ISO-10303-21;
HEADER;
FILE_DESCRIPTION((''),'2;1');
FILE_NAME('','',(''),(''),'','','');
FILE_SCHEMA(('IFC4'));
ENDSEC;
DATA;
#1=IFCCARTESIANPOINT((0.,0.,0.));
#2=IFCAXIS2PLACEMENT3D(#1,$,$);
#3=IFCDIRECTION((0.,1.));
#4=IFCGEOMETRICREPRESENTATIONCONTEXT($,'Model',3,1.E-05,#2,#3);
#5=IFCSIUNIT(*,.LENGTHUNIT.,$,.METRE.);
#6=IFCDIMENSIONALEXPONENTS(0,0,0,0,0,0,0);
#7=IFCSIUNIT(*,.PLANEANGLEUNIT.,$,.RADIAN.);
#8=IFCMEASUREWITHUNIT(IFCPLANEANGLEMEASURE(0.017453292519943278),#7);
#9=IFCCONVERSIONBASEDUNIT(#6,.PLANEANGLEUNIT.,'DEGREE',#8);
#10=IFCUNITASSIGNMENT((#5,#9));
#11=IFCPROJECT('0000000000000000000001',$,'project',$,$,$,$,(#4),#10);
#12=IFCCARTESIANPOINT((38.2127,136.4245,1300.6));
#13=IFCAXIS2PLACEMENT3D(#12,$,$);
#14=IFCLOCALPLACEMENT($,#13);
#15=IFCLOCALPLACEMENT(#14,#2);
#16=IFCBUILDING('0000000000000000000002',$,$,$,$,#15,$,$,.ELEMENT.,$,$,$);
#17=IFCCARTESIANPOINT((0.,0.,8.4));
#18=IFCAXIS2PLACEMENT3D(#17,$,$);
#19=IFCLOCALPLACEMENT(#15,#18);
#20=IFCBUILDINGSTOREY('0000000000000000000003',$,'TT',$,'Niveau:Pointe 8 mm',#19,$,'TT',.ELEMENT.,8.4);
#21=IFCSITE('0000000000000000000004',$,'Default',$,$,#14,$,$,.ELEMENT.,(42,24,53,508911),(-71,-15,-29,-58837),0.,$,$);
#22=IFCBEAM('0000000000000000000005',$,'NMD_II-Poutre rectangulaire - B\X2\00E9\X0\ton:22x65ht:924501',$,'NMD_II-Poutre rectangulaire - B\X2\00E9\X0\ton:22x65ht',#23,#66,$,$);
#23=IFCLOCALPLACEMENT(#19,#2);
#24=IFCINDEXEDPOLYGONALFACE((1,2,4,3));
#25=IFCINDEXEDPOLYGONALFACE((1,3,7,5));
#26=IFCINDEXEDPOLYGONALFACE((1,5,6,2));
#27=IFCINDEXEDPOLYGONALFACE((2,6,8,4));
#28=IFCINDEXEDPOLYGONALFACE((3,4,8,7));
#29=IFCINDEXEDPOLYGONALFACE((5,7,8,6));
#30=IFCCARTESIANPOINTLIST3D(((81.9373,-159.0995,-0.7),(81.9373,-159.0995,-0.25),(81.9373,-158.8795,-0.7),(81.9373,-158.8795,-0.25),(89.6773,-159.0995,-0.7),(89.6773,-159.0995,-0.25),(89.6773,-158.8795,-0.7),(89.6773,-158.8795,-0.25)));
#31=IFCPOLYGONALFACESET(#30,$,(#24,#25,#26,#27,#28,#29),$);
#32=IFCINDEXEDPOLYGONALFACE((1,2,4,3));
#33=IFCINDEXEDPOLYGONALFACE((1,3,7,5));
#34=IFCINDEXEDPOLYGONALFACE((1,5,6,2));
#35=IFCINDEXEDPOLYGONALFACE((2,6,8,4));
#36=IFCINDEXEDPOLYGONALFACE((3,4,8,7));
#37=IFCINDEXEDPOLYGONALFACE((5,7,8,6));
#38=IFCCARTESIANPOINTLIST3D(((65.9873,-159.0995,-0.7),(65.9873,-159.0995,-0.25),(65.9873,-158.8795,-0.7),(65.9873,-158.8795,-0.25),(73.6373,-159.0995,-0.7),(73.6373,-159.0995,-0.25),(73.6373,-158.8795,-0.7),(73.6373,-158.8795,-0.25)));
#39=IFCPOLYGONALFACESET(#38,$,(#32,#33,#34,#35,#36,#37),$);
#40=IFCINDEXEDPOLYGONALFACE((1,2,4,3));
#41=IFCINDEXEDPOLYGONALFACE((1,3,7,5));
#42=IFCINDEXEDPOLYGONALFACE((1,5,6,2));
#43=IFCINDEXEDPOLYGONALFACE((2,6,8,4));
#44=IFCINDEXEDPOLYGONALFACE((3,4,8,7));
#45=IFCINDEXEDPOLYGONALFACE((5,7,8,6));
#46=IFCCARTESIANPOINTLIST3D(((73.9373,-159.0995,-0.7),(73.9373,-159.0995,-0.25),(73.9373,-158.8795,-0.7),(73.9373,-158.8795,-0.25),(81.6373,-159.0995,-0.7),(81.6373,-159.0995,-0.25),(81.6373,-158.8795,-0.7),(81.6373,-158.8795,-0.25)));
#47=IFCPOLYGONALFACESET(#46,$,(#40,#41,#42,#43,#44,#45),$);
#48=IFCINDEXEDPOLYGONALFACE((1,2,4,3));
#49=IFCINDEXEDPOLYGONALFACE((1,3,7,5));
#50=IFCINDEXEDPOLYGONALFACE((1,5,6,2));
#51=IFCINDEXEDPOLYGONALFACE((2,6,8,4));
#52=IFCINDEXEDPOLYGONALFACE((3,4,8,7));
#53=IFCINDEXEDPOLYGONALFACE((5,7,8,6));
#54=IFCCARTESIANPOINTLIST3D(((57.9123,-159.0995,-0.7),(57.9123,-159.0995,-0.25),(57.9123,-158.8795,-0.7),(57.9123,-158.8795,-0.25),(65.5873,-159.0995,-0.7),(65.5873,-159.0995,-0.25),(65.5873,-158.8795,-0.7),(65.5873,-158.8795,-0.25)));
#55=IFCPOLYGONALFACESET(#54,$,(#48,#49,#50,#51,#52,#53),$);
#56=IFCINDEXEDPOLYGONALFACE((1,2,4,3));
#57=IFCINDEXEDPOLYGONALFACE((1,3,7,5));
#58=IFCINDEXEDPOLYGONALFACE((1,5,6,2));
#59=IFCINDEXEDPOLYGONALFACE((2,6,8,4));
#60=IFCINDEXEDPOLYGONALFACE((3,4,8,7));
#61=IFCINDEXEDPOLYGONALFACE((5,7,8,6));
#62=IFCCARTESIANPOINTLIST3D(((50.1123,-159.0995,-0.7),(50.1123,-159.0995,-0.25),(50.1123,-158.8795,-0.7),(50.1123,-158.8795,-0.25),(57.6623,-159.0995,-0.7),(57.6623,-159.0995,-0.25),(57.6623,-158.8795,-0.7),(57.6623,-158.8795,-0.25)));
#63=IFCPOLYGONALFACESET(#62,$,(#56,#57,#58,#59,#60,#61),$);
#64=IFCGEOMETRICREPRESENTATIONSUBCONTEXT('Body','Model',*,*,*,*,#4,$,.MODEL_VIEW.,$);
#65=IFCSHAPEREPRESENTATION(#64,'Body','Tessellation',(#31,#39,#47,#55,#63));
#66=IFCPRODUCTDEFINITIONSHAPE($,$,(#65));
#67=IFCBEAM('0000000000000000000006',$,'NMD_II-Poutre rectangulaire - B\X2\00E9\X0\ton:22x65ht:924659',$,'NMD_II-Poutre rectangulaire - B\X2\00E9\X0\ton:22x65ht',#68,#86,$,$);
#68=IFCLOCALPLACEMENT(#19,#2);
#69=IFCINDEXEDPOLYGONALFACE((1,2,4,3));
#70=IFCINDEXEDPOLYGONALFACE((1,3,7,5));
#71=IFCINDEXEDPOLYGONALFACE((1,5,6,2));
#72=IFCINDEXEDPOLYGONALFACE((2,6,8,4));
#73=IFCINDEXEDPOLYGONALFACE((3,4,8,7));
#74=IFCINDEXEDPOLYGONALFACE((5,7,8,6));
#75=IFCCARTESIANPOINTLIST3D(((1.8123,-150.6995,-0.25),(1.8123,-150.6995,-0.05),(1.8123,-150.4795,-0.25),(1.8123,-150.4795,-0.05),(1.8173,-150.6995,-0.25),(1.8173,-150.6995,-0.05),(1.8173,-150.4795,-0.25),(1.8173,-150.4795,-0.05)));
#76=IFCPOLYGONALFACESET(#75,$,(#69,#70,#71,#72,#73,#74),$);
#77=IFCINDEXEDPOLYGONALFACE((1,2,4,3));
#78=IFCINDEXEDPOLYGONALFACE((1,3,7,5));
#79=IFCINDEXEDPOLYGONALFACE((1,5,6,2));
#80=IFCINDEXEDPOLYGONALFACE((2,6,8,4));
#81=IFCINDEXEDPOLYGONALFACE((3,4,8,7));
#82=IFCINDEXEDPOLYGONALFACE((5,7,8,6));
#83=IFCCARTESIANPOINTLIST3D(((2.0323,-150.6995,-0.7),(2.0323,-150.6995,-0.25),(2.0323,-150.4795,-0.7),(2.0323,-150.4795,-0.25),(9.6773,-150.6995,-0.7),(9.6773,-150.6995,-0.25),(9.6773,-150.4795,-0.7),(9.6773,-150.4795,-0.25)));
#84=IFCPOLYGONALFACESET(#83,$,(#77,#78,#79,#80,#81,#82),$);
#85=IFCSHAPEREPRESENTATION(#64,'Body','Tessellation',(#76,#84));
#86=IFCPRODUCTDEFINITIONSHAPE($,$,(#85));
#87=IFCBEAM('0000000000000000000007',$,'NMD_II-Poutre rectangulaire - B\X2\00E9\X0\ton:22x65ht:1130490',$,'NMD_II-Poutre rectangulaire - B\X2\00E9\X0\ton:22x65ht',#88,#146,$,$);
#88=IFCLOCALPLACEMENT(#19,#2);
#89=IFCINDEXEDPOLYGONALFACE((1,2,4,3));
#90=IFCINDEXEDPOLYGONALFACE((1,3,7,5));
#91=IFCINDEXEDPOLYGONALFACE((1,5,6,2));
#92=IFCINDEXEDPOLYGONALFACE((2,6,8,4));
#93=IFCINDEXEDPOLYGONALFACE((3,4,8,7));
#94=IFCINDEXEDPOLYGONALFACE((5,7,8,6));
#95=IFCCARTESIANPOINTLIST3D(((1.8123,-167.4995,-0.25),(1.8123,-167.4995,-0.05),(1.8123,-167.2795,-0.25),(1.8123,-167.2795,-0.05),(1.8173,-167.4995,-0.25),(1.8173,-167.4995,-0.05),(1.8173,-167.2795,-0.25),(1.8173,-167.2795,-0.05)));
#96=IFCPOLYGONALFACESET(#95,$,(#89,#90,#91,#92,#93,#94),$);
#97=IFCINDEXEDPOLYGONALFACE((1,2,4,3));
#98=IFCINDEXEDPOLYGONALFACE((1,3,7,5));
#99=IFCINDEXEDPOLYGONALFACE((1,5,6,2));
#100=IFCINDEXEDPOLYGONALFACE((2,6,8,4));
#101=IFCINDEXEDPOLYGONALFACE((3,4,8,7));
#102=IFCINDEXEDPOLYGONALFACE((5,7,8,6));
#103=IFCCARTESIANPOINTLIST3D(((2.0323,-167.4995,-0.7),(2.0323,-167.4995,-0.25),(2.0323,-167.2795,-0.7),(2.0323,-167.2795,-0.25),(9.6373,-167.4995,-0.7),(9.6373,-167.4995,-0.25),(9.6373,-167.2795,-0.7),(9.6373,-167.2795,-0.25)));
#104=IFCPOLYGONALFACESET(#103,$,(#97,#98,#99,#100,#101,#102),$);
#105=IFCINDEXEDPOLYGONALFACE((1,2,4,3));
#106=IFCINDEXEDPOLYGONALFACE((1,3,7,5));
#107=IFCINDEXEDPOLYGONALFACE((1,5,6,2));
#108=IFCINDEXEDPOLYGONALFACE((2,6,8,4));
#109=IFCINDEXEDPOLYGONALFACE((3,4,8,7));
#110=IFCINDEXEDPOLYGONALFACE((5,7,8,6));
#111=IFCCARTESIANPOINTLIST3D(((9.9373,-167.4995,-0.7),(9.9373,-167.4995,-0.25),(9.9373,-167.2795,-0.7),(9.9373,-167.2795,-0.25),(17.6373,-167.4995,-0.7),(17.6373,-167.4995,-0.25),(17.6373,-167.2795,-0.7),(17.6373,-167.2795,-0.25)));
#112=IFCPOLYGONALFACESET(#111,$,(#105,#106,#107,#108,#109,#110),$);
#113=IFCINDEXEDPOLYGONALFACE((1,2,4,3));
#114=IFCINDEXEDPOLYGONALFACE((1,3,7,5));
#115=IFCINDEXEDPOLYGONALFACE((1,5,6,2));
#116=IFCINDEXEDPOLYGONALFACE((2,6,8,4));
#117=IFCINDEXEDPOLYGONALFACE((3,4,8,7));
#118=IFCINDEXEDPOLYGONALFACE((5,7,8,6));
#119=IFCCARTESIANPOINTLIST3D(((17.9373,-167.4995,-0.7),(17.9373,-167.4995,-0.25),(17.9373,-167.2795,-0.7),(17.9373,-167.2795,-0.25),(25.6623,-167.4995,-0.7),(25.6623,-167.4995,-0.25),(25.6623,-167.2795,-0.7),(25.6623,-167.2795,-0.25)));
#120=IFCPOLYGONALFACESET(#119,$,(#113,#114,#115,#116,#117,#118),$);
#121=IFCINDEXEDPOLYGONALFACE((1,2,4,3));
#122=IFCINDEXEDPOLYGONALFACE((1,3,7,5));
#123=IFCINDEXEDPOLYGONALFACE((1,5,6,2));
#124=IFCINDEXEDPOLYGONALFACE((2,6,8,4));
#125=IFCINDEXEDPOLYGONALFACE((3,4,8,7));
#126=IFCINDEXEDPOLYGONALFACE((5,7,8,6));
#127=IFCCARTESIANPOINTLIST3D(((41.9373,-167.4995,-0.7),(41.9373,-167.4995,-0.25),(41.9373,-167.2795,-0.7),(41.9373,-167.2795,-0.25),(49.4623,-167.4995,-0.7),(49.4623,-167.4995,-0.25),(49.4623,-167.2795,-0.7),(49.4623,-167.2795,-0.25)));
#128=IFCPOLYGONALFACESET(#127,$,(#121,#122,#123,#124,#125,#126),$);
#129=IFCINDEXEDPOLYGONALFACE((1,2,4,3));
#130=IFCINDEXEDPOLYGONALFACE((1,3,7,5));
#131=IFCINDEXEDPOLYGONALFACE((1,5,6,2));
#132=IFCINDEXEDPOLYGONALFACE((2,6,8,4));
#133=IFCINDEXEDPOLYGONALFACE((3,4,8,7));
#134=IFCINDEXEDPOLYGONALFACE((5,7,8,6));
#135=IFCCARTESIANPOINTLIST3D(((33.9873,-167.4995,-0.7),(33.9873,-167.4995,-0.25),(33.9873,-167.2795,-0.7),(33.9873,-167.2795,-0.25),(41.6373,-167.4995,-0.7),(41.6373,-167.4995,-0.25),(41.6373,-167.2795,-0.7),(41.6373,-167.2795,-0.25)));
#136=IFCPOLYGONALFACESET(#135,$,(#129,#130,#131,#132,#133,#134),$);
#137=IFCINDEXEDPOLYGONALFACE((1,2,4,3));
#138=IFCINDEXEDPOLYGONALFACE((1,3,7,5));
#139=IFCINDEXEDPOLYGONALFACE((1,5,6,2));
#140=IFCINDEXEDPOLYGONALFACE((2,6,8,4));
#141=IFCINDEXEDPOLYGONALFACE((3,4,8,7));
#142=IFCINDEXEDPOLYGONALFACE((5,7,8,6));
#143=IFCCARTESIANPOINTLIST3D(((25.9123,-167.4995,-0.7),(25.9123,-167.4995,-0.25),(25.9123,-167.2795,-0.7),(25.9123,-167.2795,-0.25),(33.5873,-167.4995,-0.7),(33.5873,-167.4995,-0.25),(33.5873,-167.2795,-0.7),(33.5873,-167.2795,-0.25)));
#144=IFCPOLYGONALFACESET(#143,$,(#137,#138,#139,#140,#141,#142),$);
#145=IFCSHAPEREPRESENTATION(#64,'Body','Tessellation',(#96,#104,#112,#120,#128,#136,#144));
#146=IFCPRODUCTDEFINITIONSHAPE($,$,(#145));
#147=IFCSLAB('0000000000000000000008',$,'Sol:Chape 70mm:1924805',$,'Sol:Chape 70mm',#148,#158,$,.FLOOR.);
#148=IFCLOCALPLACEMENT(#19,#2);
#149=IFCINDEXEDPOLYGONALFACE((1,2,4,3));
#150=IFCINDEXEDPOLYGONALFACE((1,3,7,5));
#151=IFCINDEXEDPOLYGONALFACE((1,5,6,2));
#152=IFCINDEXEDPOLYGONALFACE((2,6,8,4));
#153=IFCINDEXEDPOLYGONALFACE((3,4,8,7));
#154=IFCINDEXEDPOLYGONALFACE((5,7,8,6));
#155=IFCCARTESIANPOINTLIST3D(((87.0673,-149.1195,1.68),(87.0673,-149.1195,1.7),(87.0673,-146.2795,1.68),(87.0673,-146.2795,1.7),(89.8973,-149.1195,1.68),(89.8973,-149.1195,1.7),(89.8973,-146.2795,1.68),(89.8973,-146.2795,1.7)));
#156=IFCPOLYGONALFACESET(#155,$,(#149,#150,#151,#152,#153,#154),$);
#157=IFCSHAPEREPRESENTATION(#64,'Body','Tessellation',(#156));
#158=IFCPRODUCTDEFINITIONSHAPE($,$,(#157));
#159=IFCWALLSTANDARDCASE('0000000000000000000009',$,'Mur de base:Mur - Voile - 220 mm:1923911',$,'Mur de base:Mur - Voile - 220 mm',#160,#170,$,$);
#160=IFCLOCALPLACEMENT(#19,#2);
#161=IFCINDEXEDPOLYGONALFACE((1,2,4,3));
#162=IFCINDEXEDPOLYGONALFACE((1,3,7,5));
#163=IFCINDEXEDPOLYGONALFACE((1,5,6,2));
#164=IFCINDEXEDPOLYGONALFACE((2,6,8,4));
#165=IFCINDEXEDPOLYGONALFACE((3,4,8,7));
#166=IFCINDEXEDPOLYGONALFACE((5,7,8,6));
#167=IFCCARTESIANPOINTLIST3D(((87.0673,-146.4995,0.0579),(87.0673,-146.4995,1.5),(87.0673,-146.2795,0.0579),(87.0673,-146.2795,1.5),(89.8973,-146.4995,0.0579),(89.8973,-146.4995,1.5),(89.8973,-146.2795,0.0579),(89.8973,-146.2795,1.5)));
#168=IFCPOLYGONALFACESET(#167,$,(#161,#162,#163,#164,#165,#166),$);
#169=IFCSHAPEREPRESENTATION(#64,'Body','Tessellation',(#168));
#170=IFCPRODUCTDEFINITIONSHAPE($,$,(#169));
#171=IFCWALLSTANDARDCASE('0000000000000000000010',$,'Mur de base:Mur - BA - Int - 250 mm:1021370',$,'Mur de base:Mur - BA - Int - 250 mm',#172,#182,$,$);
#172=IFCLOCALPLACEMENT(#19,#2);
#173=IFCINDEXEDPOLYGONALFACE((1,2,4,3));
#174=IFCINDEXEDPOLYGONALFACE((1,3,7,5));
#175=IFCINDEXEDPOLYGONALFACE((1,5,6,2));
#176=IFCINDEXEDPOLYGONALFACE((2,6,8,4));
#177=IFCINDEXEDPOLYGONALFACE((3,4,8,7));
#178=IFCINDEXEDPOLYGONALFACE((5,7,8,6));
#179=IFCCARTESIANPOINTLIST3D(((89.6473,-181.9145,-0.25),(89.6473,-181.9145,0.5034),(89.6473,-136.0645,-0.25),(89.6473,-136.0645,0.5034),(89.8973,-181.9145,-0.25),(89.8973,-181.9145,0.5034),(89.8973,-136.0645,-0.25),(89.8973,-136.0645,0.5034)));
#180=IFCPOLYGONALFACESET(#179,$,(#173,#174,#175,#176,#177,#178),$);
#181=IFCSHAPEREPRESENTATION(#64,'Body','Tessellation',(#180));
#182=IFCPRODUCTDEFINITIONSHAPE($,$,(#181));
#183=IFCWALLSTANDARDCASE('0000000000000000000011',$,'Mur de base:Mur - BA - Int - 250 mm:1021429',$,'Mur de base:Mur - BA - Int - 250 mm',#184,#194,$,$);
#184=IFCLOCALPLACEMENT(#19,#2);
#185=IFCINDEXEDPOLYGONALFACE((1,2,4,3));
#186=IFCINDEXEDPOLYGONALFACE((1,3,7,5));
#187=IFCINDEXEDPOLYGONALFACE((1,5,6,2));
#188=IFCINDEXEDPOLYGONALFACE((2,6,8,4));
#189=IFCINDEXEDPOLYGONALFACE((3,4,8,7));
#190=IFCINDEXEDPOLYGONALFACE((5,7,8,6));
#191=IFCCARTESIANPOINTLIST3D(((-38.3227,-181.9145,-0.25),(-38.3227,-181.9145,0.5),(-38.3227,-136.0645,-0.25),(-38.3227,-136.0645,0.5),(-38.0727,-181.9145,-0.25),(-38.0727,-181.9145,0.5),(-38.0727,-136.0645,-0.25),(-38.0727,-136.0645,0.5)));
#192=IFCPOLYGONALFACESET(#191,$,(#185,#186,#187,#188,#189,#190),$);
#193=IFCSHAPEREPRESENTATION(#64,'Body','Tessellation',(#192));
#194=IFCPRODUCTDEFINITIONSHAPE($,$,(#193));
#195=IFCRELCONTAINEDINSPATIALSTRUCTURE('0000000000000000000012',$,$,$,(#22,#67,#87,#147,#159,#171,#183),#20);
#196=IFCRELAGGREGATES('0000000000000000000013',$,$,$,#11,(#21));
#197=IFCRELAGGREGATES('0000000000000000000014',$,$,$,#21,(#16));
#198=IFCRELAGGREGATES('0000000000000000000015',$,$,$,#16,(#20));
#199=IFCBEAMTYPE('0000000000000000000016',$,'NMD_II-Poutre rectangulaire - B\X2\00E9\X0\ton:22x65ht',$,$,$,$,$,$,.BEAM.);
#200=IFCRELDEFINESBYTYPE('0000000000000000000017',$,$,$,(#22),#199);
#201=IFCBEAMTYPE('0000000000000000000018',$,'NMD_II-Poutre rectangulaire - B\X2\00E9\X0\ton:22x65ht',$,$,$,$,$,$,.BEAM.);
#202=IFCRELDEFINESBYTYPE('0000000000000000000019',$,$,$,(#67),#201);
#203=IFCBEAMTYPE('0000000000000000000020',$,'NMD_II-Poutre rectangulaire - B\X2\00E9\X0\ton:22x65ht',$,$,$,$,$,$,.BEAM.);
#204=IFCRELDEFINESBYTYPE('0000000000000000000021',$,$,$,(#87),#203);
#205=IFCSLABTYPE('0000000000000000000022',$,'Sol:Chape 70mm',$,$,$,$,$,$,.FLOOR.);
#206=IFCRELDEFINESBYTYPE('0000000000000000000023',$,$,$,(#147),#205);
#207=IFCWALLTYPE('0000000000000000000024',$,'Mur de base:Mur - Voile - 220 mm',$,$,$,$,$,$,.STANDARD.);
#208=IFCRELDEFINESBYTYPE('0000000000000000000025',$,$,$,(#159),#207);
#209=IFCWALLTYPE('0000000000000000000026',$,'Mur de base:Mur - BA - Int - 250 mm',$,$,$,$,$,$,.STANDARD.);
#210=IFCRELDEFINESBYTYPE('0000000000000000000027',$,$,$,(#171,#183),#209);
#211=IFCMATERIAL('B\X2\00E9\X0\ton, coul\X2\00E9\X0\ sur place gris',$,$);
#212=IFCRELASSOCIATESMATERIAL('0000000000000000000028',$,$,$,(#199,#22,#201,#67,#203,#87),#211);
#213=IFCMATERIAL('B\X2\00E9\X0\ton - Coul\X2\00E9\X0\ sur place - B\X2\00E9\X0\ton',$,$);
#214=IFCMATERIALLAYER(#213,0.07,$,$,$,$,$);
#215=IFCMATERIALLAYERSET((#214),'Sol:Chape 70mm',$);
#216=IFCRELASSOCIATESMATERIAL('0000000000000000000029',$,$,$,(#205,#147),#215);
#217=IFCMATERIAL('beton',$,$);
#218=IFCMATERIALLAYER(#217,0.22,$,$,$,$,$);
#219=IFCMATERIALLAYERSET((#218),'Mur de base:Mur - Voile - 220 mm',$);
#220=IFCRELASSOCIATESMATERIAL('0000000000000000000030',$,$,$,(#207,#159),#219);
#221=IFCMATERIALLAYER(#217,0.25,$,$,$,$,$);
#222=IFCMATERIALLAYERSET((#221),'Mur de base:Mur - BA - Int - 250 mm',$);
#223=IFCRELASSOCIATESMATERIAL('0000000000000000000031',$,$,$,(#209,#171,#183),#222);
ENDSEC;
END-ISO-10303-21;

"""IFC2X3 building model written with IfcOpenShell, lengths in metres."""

from ifc_helpers import new_model, entity, si_unit, converted_unit, direction, frame, frame_2d, origin, place, context, subcontext, project, spatial, rectangle, extrude, source, transform, mapped, material, layer, layer_set, layer_usage, type_object, type_shapes, element, save


model = new_model("IFC2X3")

# Units and contexts
model_context = context("Model", 3, precision=1e-05, world=origin(), true_north=direction((0.0, 1.0)))
body_context = subcontext(model_context, "Body", "Model", "MODEL_VIEW")
ifc_project = project(units=[si_unit("LENGTHUNIT", "METRE"), converted_unit("PLANEANGLEUNIT", "DEGREE", entity("IfcPlaneAngleMeasure", 0.017453292519943278), si_unit("PLANEANGLEUNIT", "RADIAN"), dimensions=[0, 0, 0, 0, 0, 0, 0])], contexts=[model_context])

# Site, building, storey
site_placement = place(None, frame((38.2127, 136.4245, 1300.6)))
site = spatial("IfcSite", under=ifc_project, at=site_placement, Name="Default", CompositionType="ELEMENT", RefLatitude=(42, 24, 53, 508911), RefLongitude=(-71, -15, -29, -58837), RefElevation=0.0)
building_placement = place(site_placement, origin())
building = spatial("IfcBuilding", under=site, at=building_placement, CompositionType="ELEMENT")
storey_placement = place(building_placement, frame((0.0, 0.0, 8.4)))
storey = spatial("IfcBuildingStorey", under=building, at=storey_placement, Name="TT", ObjectType="Niveau:Pointe 8 mm", LongName="TT", CompositionType="ELEMENT", Elevation=8.4)

# Beams
ifc_material_1 = material(Name="Béton, coulé sur place gris")
beam_type_1 = type_object("IfcBeamType", Name="NMD_II-Poutre rectangulaire - Béton:22x65ht", PredefinedType="BEAM", material=ifc_material_1)
shared_shape_1 = source(origin(), body_context, "Body", "SweptSolid", [
    extrude(rectangle(XDim=0.45, YDim=0.22, at=frame_2d((0.0, 0.0), x_axis=(1.0, 0.0))), frame((81.9373, -158.9895, 7.925), z_axis=(1.0, 0.0, 0.0), x_axis=(0.0, 0.0, -1.0)), (0.0, 0.0, 1.0), 7.74),
    extrude(rectangle(XDim=0.45, YDim=0.22, at=frame_2d((0.0, 0.0), x_axis=(1.0, 0.0))), frame((65.9873, -158.9895, 7.925), z_axis=(1.0, 0.0, 0.0), x_axis=(0.0, 0.0, -1.0)), (0.0, 0.0, 1.0), 7.65),
    extrude(rectangle(XDim=0.45, YDim=0.22, at=frame_2d((0.0, 0.0), x_axis=(1.0, 0.0))), frame((73.9373, -158.9895, 7.925), z_axis=(1.0, 0.0, 0.0), x_axis=(0.0, 0.0, -1.0)), (0.0, 0.0, 1.0), 7.7),
    extrude(rectangle(XDim=0.45, YDim=0.22, at=frame_2d((0.0, 0.0), x_axis=(1.0, 0.0))), frame((57.9123, -158.9895, 7.925), z_axis=(1.0, 0.0, 0.0), x_axis=(0.0, 0.0, -1.0)), (0.0, 0.0, 1.0), 7.675),
    extrude(rectangle(XDim=0.45, YDim=0.22, at=frame_2d((0.0, 0.0), x_axis=(1.0, 0.0))), frame((50.1123, -158.9895, 7.925), z_axis=(1.0, 0.0, 0.0), x_axis=(0.0, 0.0, -1.0)), (0.0, 0.0, 1.0), 7.55),
])
type_shapes(beam_type_1, [shared_shape_1])
beam_1_placement = place(storey_placement, frame((0.0, 0.0, -8.4)))
element("IfcBeam", 1, at=beam_1_placement, inside=storey, type_object=beam_type_1, material=ifc_material_1, Name="NMD_II-Poutre rectangulaire - Béton:22x65ht:924501", ObjectType="NMD_II-Poutre rectangulaire - Béton:22x65ht", context=body_context, shape_type="MappedRepresentation", body=[
    mapped(shared_shape_1, transform((0.0, 0.0, 0.0), scale=1.0)),
])
beam_type_2 = type_object("IfcBeamType", Name="NMD_II-Poutre rectangulaire - Béton:22x65ht", PredefinedType="BEAM", material=ifc_material_1)
shared_shape_2 = source(origin(), body_context, "Body", "SweptSolid", [
    extrude(rectangle(XDim=0.2, YDim=0.22, at=frame_2d((0.0, 0.0), x_axis=(1.0, 0.0))), frame((1.8123, -150.5895, 8.25), z_axis=(1.0, 0.0, 0.0), x_axis=(0.0, 0.0, -1.0)), (0.0, 0.0, 1.0), 0.005),
    extrude(rectangle(XDim=0.45, YDim=0.22, at=frame_2d((0.0, 0.0), x_axis=(1.0, 0.0))), frame((2.0323, -150.5895, 7.925), z_axis=(1.0, 0.0, 0.0), x_axis=(0.0, 0.0, -1.0)), (0.0, 0.0, 1.0), 7.645),
])
type_shapes(beam_type_2, [shared_shape_2])
beam_2_placement = place(storey_placement, frame((0.0, 0.0, -8.4)))
element("IfcBeam", 2, at=beam_2_placement, inside=storey, type_object=beam_type_2, material=ifc_material_1, Name="NMD_II-Poutre rectangulaire - Béton:22x65ht:924659", ObjectType="NMD_II-Poutre rectangulaire - Béton:22x65ht", context=body_context, shape_type="MappedRepresentation", body=[
    mapped(shared_shape_2, transform((0.0, 0.0, 0.0), scale=1.0)),
])
beam_type_3 = type_object("IfcBeamType", Name="NMD_II-Poutre rectangulaire - Béton:22x65ht", PredefinedType="BEAM", material=ifc_material_1)
shared_shape_3 = source(origin(), body_context, "Body", "SweptSolid", [
    extrude(rectangle(XDim=0.2, YDim=0.22, at=frame_2d((0.0, 0.0), x_axis=(1.0, 0.0))), frame((1.8123, -167.3895, 8.25), z_axis=(1.0, 0.0, 0.0), x_axis=(0.0, 0.0, -1.0)), (0.0, 0.0, 1.0), 0.005),
    extrude(rectangle(XDim=0.45, YDim=0.22, at=frame_2d((0.0, 0.0), x_axis=(1.0, 0.0))), frame((2.0323, -167.3895, 7.925), z_axis=(1.0, 0.0, 0.0), x_axis=(0.0, 0.0, -1.0)), (0.0, 0.0, 1.0), 7.605),
    extrude(rectangle(XDim=0.45, YDim=0.22, at=frame_2d((0.0, 0.0), x_axis=(1.0, 0.0))), frame((9.9373, -167.3895, 7.925), z_axis=(1.0, 0.0, 0.0), x_axis=(0.0, 0.0, -1.0)), (0.0, 0.0, 1.0), 7.7),
    extrude(rectangle(XDim=0.45, YDim=0.22, at=frame_2d((0.0, 0.0), x_axis=(1.0, 0.0))), frame((17.9373, -167.3895, 7.925), z_axis=(1.0, 0.0, 0.0), x_axis=(0.0, 0.0, -1.0)), (0.0, 0.0, 1.0), 7.725),
    extrude(rectangle(XDim=0.45, YDim=0.22, at=frame_2d((0.0, 0.0), x_axis=(1.0, 0.0))), frame((41.9373, -167.3895, 7.925), z_axis=(1.0, 0.0, 0.0), x_axis=(0.0, 0.0, -1.0)), (0.0, 0.0, 1.0), 7.525),
    extrude(rectangle(XDim=0.45, YDim=0.22, at=frame_2d((0.0, 0.0), x_axis=(1.0, 0.0))), frame((33.9873, -167.3895, 7.925), z_axis=(1.0, 0.0, 0.0), x_axis=(0.0, 0.0, -1.0)), (0.0, 0.0, 1.0), 7.65),
    extrude(rectangle(XDim=0.45, YDim=0.22, at=frame_2d((0.0, 0.0), x_axis=(1.0, 0.0))), frame((25.9123, -167.3895, 7.925), z_axis=(1.0, 0.0, 0.0), x_axis=(0.0, 0.0, -1.0)), (0.0, 0.0, 1.0), 7.675),
])
type_shapes(beam_type_3, [shared_shape_3])
beam_3_placement = place(storey_placement, frame((0.0, 0.0, -8.4)))
element("IfcBeam", 3, at=beam_3_placement, inside=storey, type_object=beam_type_3, material=ifc_material_1, Name="NMD_II-Poutre rectangulaire - Béton:22x65ht:1130490", ObjectType="NMD_II-Poutre rectangulaire - Béton:22x65ht", context=body_context, shape_type="MappedRepresentation", body=[
    mapped(shared_shape_3, transform((0.0, 0.0, 0.0), scale=1.0)),
])

# Slab
ifc_material_2 = material(Name="Béton - Coulé sur place - Béton")
ifc_layer_1 = layer(ifc_material_2, 0.07)
ifc_layer_set_1 = layer_set([ifc_layer_1], Name="Sol:Chape 70mm")
ifc_layer_usage_1 = layer_usage(ifc_layer_set_1, "AXIS3", "POSITIVE", 0.0)
slab_type = type_object("IfcSlabType", Name="Sol:Chape 70mm", PredefinedType="FLOOR", material=ifc_layer_set_1)
slab_placement = place(storey_placement, origin())
element("IfcSlab", 4, at=slab_placement, inside=storey, type_object=slab_type, material=ifc_layer_usage_1, Name="Sol:Chape 70mm:1924805", ObjectType="Sol:Chape 70mm", PredefinedType="FLOOR", context=body_context, shape_type="SweptSolid", body=[
    extrude(rectangle(XDim=2.84, YDim=2.83, at=frame_2d((0.0, 0.0), x_axis=(1.0, 0.0))), frame((88.4823, -147.6995, 1.7), z_axis=(0.0, 0.0, -1.0), x_axis=(0.0, 1.0, 0.0)), (0.0, 0.0, 1.0), 0.02),
])

# Walls
ifc_material_3 = material(Name="beton")
ifc_layer_2 = layer(ifc_material_3, 0.22)
ifc_layer_set_2 = layer_set([ifc_layer_2], Name="Mur de base:Mur - Voile - 220 mm")
ifc_layer_usage_2 = layer_usage(ifc_layer_set_2, "AXIS2", "NEGATIVE", 0.11)
wall_type_1 = type_object("IfcWallType", Name="Mur de base:Mur - Voile - 220 mm", PredefinedType="STANDARD", material=ifc_layer_set_2)
wall_1_placement = place(storey_placement, frame((87.0673, -146.3895, 0.0579)))
element("IfcWallStandardCase", 5, at=wall_1_placement, inside=storey, type_object=wall_type_1, material=ifc_layer_usage_2, Name="Mur de base:Mur - Voile - 220 mm:1923911", ObjectType="Mur de base:Mur - Voile - 220 mm", context=body_context, shape_type="SweptSolid", body=[
    extrude(rectangle(XDim=2.83, YDim=0.22, at=frame_2d((1.415, 0.0), x_axis=(-1.0, 0.0))), origin(), (0.0, 0.0, 1.0), 1.4421),
])
ifc_layer_3 = layer(ifc_material_3, 0.25)
ifc_layer_set_3 = layer_set([ifc_layer_3], Name="Mur de base:Mur - BA - Int - 250 mm")
ifc_layer_usage_3 = layer_usage(ifc_layer_set_3, "AXIS2", "NEGATIVE", 0.125)
wall_type_2 = type_object("IfcWallType", Name="Mur de base:Mur - BA - Int - 250 mm", PredefinedType="STANDARD", material=ifc_layer_set_3)
wall_2_placement = place(storey_placement, frame((89.7723, -136.0645, -0.25), z_axis=(0.0, 0.0, 1.0), x_axis=(0.0, -1.0, 0.0)))
element("IfcWallStandardCase", 6, at=wall_2_placement, inside=storey, type_object=wall_type_2, material=ifc_layer_usage_3, Name="Mur de base:Mur - BA - Int - 250 mm:1021370", ObjectType="Mur de base:Mur - BA - Int - 250 mm", context=body_context, shape_type="SweptSolid", body=[
    extrude(rectangle(XDim=45.85, YDim=0.25, at=frame_2d((22.925, 0.0), x_axis=(-1.0, 0.0))), origin(), (0.0, 0.0, 1.0), 0.7534),
])
ifc_layer_usage_4 = layer_usage(ifc_layer_set_3, "AXIS2", "NEGATIVE", 0.125)
wall_3_placement = place(storey_placement, frame((-38.1977, -136.0645, -0.25), z_axis=(0.0, 0.0, 1.0), x_axis=(0.0, -1.0, 0.0)))
element("IfcWallStandardCase", 7, at=wall_3_placement, inside=storey, type_object=wall_type_2, material=ifc_layer_usage_4, Name="Mur de base:Mur - BA - Int - 250 mm:1021429", ObjectType="Mur de base:Mur - BA - Int - 250 mm", context=body_context, shape_type="SweptSolid", body=[
    extrude(rectangle(XDim=45.85, YDim=0.25, at=frame_2d((22.925, 0.0), x_axis=(-1.0, 0.0))), origin(), (0.0, 0.0, 1.0), 0.75),
])

save(model, "model.ifc")
